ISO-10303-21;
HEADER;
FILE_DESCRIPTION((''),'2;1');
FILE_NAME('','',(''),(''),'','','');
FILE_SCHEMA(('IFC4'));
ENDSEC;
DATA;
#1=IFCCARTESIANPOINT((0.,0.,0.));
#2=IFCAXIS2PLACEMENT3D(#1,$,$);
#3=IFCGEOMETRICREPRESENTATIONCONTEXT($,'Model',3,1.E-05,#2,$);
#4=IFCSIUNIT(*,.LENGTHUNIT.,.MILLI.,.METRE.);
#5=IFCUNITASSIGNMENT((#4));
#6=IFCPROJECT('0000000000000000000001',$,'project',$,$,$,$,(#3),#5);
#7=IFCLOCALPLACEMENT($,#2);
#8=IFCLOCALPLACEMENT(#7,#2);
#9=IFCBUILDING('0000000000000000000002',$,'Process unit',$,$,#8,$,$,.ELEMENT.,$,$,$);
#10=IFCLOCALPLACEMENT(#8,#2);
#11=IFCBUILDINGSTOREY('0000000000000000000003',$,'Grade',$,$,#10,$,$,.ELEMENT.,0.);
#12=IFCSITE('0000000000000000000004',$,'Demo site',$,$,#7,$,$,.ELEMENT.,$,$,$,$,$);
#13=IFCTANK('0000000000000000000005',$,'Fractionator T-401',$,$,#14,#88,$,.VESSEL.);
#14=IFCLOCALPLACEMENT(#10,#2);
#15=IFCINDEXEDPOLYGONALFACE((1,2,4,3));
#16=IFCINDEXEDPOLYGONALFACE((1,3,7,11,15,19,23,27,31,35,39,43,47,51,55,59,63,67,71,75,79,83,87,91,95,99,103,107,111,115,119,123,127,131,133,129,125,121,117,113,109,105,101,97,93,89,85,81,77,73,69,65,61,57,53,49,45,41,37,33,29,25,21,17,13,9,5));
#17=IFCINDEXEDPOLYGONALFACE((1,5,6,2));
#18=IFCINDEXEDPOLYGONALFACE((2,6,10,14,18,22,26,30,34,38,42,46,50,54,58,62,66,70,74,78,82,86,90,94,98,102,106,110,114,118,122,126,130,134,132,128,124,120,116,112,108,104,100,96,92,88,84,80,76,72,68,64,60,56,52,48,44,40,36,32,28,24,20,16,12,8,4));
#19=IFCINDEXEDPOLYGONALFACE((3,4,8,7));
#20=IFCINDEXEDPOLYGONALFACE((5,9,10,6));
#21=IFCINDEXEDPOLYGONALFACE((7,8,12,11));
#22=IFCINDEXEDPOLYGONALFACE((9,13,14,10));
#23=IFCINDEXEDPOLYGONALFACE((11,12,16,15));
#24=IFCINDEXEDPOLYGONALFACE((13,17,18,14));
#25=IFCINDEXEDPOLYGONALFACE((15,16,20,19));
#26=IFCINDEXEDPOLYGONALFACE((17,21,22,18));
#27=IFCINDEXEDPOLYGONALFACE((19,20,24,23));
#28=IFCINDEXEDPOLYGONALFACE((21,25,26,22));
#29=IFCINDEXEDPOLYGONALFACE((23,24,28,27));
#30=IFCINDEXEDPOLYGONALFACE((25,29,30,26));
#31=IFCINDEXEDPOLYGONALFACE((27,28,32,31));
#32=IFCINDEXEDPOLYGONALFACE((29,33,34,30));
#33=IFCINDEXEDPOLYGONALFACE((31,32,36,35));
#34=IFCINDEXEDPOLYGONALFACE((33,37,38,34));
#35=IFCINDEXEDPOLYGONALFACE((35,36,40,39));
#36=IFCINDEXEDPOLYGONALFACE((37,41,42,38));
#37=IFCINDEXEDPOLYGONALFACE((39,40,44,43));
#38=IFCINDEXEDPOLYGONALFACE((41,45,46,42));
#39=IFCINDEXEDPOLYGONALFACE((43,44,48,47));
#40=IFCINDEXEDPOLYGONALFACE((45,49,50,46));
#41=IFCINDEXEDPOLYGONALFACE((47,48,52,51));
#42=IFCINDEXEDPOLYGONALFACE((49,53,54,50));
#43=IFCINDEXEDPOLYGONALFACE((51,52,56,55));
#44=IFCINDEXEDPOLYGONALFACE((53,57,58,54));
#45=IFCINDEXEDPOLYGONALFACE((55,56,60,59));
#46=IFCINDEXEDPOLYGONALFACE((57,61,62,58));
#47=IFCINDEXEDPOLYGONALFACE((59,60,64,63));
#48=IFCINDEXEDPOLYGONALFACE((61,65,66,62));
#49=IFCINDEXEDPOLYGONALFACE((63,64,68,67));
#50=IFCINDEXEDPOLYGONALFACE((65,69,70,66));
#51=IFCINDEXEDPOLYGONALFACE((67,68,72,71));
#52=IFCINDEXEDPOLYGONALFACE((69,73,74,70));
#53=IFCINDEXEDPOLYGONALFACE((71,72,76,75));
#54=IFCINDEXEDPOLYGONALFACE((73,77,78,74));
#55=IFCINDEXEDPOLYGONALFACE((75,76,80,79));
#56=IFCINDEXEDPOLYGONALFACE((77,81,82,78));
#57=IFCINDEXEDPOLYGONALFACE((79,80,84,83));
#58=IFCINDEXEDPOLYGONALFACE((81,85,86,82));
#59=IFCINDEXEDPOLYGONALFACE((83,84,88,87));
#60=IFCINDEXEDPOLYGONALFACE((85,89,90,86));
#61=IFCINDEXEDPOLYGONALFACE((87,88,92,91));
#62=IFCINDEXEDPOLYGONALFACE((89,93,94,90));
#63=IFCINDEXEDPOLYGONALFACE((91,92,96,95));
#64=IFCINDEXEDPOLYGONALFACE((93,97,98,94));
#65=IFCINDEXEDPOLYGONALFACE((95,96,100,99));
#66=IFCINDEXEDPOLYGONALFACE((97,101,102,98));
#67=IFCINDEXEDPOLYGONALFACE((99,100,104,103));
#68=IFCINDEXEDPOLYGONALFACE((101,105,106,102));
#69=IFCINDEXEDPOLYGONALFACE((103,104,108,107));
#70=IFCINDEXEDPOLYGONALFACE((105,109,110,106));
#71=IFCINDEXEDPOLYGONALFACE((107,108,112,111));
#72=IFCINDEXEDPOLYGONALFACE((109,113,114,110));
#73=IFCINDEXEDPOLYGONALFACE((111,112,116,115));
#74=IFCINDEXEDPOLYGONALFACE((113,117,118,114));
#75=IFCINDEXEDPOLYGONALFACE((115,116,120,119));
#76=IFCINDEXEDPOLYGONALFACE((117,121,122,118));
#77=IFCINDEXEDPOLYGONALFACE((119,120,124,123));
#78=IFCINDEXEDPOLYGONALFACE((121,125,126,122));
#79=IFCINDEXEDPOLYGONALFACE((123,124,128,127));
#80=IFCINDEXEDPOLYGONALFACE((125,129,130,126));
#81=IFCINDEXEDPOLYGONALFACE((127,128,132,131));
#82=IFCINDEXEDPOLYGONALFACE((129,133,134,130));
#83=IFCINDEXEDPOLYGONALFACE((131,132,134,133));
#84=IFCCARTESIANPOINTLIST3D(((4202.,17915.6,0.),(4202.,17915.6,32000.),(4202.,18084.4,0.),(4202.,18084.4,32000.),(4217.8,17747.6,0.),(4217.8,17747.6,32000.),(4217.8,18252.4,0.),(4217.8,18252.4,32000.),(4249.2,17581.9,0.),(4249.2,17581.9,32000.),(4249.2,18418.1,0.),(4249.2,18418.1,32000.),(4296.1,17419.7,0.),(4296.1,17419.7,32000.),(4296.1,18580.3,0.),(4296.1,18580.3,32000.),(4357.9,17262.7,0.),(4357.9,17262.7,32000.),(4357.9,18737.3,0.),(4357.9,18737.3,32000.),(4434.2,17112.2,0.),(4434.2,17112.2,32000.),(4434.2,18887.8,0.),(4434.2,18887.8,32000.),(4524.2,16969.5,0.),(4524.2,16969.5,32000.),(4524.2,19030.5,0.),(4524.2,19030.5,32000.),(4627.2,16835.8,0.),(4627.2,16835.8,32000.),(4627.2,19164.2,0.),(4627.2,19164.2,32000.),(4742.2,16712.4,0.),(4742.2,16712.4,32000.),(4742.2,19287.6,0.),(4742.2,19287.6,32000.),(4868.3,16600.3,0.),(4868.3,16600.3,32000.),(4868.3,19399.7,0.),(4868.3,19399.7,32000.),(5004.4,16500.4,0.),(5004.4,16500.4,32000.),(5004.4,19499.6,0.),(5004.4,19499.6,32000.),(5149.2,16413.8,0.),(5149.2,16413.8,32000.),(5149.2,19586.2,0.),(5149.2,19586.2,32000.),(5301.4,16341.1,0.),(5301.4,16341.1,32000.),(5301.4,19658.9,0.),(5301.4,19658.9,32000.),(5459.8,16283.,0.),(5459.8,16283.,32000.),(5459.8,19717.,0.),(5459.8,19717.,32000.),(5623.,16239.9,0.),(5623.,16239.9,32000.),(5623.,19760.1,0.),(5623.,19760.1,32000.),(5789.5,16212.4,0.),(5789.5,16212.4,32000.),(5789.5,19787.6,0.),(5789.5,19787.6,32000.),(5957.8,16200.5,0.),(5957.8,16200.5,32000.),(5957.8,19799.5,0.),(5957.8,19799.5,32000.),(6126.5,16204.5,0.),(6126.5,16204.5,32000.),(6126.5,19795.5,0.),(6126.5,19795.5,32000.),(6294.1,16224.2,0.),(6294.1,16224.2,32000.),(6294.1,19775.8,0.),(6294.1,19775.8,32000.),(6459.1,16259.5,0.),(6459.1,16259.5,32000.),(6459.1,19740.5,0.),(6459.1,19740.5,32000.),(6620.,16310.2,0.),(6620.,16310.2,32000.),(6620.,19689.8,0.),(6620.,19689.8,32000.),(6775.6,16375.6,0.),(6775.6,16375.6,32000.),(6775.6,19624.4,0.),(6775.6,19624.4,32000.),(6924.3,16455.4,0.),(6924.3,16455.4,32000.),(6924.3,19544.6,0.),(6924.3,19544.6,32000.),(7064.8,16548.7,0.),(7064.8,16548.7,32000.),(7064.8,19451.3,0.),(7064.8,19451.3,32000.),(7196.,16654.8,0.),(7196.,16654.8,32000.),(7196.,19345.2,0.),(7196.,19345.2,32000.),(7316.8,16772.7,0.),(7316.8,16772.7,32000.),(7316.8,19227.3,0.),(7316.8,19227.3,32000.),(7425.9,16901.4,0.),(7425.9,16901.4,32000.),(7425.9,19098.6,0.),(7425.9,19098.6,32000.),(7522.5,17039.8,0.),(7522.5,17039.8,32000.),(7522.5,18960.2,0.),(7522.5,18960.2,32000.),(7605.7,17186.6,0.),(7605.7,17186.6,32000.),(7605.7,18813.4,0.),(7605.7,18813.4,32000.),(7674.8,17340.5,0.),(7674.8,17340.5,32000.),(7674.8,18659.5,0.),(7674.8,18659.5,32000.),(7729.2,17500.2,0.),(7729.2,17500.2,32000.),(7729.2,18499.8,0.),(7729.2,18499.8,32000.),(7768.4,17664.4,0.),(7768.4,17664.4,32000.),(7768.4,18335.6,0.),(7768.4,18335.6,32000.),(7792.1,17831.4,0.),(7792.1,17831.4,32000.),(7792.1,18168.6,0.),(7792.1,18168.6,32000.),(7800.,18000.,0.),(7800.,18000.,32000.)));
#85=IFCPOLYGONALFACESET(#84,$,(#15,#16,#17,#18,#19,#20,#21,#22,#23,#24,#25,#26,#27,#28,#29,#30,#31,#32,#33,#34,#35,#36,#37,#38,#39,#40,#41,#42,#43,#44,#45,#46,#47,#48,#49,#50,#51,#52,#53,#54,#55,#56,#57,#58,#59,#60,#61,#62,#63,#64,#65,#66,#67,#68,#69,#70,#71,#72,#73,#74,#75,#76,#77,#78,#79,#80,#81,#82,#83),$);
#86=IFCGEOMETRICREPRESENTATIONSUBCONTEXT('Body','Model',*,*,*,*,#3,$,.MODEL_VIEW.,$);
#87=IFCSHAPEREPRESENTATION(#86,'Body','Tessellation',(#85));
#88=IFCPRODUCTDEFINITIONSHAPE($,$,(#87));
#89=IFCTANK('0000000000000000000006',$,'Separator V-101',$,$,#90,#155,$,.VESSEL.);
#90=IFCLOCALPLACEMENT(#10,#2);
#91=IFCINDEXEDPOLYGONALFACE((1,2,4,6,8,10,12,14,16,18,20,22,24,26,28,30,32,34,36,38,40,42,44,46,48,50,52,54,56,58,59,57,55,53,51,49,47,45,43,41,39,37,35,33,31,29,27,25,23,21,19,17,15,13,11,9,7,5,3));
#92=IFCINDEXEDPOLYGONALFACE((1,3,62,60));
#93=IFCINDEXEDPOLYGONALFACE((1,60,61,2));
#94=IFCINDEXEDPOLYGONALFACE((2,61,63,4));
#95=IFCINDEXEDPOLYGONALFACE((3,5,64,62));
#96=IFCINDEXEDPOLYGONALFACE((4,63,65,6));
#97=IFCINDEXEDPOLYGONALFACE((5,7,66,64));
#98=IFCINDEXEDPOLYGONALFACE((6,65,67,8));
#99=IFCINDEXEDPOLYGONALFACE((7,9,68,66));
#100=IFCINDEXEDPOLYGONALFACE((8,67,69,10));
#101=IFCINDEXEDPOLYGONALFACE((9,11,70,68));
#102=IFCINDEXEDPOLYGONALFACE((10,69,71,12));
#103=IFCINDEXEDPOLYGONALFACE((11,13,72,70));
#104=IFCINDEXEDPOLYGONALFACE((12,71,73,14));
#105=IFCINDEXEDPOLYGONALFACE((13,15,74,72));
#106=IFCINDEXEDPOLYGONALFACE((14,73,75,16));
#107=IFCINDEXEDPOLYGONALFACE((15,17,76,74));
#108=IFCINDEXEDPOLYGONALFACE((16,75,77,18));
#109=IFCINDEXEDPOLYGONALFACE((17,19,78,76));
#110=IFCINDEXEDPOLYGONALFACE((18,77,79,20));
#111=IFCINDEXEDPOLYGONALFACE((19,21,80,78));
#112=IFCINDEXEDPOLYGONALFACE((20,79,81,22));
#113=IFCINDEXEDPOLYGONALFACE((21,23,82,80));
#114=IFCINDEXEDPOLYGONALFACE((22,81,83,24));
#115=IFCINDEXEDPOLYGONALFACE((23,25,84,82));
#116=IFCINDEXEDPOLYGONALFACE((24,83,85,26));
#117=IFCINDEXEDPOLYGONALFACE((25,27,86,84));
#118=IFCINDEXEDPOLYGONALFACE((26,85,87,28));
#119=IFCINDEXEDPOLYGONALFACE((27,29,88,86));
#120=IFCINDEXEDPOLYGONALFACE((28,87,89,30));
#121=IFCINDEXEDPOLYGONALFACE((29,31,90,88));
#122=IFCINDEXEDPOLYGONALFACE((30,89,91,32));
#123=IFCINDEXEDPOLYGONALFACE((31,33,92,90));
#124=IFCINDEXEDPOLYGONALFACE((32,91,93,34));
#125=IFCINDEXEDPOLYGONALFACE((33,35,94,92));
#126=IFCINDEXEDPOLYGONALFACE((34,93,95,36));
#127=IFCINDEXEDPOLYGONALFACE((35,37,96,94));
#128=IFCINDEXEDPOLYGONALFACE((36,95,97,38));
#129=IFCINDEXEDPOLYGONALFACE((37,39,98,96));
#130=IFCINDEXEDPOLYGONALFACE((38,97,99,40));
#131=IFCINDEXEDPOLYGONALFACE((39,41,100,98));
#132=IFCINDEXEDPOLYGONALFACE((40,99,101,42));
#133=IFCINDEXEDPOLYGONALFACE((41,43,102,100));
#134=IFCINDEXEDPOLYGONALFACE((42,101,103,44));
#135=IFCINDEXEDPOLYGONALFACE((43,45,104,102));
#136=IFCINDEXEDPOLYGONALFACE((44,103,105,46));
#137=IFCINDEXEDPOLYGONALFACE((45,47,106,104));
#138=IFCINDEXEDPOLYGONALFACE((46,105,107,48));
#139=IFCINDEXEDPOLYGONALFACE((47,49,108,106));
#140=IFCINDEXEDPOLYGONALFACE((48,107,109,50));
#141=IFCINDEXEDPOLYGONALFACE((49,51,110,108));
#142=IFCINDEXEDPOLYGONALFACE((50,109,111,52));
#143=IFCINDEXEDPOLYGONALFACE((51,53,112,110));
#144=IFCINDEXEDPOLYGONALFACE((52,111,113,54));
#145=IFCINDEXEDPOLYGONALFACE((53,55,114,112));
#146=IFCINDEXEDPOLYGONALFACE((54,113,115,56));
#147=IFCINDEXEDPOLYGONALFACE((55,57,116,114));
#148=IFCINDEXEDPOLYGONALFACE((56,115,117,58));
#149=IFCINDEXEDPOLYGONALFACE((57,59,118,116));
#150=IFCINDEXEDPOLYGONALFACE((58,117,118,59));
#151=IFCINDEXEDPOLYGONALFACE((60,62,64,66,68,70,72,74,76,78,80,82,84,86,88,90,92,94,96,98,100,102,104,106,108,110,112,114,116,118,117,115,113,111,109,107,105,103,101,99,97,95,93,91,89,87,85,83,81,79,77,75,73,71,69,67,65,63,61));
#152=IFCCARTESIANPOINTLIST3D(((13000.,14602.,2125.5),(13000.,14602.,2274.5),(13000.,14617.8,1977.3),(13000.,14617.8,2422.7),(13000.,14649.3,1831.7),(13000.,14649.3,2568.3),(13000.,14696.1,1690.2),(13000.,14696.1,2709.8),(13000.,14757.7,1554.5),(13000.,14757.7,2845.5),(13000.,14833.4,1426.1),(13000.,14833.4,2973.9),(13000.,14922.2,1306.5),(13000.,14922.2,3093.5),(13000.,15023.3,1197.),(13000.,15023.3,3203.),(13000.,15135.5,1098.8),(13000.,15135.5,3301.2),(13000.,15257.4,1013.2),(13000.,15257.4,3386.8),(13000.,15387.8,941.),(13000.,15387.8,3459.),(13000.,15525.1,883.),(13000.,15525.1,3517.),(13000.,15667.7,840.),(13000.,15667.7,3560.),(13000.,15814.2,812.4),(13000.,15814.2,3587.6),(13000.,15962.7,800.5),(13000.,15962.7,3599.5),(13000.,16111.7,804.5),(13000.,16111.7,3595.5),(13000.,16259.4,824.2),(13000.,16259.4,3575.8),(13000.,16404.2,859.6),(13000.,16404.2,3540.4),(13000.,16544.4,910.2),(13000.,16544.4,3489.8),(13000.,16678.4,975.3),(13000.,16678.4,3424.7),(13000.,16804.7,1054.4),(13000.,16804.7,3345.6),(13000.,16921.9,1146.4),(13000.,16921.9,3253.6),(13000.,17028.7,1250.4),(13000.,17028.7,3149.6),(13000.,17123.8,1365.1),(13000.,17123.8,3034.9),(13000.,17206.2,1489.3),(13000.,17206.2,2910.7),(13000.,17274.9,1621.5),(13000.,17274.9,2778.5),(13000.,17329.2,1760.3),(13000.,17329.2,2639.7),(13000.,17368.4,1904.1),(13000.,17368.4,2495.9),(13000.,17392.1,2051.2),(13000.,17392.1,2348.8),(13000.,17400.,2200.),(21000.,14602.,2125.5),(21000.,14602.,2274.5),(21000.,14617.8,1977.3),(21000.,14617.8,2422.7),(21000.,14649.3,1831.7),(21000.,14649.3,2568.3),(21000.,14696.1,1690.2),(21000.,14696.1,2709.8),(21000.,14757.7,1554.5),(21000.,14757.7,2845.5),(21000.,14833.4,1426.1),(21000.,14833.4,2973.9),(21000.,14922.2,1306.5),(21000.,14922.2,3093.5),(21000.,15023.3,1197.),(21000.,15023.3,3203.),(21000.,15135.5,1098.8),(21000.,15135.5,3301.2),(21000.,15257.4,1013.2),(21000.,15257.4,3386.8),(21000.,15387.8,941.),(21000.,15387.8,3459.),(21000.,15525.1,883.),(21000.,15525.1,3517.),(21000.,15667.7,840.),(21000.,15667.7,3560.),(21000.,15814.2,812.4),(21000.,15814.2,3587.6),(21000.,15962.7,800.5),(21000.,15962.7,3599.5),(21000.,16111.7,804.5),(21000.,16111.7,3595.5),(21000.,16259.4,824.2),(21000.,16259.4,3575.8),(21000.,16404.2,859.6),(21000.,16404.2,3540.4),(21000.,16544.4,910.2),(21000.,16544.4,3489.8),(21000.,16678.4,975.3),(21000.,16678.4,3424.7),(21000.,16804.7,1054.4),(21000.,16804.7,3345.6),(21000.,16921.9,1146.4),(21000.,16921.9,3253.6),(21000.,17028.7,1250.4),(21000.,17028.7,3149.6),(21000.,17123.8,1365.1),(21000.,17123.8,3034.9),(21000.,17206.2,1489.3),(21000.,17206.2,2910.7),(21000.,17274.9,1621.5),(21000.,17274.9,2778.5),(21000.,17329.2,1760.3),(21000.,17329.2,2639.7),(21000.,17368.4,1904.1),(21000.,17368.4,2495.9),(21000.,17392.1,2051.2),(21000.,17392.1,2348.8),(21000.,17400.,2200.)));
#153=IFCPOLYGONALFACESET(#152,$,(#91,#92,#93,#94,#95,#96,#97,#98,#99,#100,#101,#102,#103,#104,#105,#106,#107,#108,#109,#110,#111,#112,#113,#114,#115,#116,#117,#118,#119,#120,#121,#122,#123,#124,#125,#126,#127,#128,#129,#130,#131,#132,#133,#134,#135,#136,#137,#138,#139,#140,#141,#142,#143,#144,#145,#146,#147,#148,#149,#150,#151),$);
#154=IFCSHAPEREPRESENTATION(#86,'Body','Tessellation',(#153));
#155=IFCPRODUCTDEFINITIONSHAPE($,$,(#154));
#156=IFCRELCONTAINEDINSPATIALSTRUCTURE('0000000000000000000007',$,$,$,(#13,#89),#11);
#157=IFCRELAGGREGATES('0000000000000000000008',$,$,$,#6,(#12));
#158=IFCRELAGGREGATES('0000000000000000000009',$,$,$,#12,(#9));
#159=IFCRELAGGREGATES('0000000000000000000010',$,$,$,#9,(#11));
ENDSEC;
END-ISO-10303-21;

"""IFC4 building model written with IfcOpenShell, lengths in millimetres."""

from ifc_helpers import new_model, si_unit, frame, origin, place, context, subcontext, project, spatial, circle, extrude, element, save


model = new_model("IFC4")

# Units and contexts
model_context = context("Model", 3, precision=1e-05, world=origin())
body_context = subcontext(model_context, "Body", "Model", "MODEL_VIEW")
ifc_project = project(units=[si_unit("LENGTHUNIT", "METRE", prefix="MILLI")], contexts=[model_context])

# Site, building, storey
site_placement = place(None, origin())
site = spatial("IfcSite", under=ifc_project, at=site_placement, Name="Demo site", CompositionType="ELEMENT")
building_placement = place(site_placement, origin())
building = spatial("IfcBuilding", under=site, at=building_placement, Name="Process unit", CompositionType="ELEMENT")
storey_placement = place(building_placement, origin())
storey = spatial("IfcBuildingStorey", under=building, at=storey_placement, Name="Grade", CompositionType="ELEMENT", Elevation=0.0)

# Tanks
tank_1_placement = place(storey_placement, frame((6000.0, 18000.0, 0.0)))
element("IfcTank", 1, at=tank_1_placement, inside=storey, Name="Fractionator T-401", PredefinedType="VESSEL", context=body_context, shape_type="SweptSolid", body=[
    extrude(circle(Radius=1800.0), origin(), (0.0, 0.0, 1.0), 32000.0),
])
tank_2_placement = place(storey_placement, frame((13000.0, 16000.0, 2200.0)))
element("IfcTank", 2, at=tank_2_placement, inside=storey, Name="Separator V-101", PredefinedType="VESSEL", context=body_context, shape_type="SweptSolid", body=[
    extrude(circle(Radius=1400.0), frame((0.0, 0.0, 0.0), z_axis=(1.0, 0.0, 0.0), x_axis=(0.0, 1.0, 0.0)), (0.0, 0.0, 1.0), 8000.0),
])

save(model, "model.ifc")
